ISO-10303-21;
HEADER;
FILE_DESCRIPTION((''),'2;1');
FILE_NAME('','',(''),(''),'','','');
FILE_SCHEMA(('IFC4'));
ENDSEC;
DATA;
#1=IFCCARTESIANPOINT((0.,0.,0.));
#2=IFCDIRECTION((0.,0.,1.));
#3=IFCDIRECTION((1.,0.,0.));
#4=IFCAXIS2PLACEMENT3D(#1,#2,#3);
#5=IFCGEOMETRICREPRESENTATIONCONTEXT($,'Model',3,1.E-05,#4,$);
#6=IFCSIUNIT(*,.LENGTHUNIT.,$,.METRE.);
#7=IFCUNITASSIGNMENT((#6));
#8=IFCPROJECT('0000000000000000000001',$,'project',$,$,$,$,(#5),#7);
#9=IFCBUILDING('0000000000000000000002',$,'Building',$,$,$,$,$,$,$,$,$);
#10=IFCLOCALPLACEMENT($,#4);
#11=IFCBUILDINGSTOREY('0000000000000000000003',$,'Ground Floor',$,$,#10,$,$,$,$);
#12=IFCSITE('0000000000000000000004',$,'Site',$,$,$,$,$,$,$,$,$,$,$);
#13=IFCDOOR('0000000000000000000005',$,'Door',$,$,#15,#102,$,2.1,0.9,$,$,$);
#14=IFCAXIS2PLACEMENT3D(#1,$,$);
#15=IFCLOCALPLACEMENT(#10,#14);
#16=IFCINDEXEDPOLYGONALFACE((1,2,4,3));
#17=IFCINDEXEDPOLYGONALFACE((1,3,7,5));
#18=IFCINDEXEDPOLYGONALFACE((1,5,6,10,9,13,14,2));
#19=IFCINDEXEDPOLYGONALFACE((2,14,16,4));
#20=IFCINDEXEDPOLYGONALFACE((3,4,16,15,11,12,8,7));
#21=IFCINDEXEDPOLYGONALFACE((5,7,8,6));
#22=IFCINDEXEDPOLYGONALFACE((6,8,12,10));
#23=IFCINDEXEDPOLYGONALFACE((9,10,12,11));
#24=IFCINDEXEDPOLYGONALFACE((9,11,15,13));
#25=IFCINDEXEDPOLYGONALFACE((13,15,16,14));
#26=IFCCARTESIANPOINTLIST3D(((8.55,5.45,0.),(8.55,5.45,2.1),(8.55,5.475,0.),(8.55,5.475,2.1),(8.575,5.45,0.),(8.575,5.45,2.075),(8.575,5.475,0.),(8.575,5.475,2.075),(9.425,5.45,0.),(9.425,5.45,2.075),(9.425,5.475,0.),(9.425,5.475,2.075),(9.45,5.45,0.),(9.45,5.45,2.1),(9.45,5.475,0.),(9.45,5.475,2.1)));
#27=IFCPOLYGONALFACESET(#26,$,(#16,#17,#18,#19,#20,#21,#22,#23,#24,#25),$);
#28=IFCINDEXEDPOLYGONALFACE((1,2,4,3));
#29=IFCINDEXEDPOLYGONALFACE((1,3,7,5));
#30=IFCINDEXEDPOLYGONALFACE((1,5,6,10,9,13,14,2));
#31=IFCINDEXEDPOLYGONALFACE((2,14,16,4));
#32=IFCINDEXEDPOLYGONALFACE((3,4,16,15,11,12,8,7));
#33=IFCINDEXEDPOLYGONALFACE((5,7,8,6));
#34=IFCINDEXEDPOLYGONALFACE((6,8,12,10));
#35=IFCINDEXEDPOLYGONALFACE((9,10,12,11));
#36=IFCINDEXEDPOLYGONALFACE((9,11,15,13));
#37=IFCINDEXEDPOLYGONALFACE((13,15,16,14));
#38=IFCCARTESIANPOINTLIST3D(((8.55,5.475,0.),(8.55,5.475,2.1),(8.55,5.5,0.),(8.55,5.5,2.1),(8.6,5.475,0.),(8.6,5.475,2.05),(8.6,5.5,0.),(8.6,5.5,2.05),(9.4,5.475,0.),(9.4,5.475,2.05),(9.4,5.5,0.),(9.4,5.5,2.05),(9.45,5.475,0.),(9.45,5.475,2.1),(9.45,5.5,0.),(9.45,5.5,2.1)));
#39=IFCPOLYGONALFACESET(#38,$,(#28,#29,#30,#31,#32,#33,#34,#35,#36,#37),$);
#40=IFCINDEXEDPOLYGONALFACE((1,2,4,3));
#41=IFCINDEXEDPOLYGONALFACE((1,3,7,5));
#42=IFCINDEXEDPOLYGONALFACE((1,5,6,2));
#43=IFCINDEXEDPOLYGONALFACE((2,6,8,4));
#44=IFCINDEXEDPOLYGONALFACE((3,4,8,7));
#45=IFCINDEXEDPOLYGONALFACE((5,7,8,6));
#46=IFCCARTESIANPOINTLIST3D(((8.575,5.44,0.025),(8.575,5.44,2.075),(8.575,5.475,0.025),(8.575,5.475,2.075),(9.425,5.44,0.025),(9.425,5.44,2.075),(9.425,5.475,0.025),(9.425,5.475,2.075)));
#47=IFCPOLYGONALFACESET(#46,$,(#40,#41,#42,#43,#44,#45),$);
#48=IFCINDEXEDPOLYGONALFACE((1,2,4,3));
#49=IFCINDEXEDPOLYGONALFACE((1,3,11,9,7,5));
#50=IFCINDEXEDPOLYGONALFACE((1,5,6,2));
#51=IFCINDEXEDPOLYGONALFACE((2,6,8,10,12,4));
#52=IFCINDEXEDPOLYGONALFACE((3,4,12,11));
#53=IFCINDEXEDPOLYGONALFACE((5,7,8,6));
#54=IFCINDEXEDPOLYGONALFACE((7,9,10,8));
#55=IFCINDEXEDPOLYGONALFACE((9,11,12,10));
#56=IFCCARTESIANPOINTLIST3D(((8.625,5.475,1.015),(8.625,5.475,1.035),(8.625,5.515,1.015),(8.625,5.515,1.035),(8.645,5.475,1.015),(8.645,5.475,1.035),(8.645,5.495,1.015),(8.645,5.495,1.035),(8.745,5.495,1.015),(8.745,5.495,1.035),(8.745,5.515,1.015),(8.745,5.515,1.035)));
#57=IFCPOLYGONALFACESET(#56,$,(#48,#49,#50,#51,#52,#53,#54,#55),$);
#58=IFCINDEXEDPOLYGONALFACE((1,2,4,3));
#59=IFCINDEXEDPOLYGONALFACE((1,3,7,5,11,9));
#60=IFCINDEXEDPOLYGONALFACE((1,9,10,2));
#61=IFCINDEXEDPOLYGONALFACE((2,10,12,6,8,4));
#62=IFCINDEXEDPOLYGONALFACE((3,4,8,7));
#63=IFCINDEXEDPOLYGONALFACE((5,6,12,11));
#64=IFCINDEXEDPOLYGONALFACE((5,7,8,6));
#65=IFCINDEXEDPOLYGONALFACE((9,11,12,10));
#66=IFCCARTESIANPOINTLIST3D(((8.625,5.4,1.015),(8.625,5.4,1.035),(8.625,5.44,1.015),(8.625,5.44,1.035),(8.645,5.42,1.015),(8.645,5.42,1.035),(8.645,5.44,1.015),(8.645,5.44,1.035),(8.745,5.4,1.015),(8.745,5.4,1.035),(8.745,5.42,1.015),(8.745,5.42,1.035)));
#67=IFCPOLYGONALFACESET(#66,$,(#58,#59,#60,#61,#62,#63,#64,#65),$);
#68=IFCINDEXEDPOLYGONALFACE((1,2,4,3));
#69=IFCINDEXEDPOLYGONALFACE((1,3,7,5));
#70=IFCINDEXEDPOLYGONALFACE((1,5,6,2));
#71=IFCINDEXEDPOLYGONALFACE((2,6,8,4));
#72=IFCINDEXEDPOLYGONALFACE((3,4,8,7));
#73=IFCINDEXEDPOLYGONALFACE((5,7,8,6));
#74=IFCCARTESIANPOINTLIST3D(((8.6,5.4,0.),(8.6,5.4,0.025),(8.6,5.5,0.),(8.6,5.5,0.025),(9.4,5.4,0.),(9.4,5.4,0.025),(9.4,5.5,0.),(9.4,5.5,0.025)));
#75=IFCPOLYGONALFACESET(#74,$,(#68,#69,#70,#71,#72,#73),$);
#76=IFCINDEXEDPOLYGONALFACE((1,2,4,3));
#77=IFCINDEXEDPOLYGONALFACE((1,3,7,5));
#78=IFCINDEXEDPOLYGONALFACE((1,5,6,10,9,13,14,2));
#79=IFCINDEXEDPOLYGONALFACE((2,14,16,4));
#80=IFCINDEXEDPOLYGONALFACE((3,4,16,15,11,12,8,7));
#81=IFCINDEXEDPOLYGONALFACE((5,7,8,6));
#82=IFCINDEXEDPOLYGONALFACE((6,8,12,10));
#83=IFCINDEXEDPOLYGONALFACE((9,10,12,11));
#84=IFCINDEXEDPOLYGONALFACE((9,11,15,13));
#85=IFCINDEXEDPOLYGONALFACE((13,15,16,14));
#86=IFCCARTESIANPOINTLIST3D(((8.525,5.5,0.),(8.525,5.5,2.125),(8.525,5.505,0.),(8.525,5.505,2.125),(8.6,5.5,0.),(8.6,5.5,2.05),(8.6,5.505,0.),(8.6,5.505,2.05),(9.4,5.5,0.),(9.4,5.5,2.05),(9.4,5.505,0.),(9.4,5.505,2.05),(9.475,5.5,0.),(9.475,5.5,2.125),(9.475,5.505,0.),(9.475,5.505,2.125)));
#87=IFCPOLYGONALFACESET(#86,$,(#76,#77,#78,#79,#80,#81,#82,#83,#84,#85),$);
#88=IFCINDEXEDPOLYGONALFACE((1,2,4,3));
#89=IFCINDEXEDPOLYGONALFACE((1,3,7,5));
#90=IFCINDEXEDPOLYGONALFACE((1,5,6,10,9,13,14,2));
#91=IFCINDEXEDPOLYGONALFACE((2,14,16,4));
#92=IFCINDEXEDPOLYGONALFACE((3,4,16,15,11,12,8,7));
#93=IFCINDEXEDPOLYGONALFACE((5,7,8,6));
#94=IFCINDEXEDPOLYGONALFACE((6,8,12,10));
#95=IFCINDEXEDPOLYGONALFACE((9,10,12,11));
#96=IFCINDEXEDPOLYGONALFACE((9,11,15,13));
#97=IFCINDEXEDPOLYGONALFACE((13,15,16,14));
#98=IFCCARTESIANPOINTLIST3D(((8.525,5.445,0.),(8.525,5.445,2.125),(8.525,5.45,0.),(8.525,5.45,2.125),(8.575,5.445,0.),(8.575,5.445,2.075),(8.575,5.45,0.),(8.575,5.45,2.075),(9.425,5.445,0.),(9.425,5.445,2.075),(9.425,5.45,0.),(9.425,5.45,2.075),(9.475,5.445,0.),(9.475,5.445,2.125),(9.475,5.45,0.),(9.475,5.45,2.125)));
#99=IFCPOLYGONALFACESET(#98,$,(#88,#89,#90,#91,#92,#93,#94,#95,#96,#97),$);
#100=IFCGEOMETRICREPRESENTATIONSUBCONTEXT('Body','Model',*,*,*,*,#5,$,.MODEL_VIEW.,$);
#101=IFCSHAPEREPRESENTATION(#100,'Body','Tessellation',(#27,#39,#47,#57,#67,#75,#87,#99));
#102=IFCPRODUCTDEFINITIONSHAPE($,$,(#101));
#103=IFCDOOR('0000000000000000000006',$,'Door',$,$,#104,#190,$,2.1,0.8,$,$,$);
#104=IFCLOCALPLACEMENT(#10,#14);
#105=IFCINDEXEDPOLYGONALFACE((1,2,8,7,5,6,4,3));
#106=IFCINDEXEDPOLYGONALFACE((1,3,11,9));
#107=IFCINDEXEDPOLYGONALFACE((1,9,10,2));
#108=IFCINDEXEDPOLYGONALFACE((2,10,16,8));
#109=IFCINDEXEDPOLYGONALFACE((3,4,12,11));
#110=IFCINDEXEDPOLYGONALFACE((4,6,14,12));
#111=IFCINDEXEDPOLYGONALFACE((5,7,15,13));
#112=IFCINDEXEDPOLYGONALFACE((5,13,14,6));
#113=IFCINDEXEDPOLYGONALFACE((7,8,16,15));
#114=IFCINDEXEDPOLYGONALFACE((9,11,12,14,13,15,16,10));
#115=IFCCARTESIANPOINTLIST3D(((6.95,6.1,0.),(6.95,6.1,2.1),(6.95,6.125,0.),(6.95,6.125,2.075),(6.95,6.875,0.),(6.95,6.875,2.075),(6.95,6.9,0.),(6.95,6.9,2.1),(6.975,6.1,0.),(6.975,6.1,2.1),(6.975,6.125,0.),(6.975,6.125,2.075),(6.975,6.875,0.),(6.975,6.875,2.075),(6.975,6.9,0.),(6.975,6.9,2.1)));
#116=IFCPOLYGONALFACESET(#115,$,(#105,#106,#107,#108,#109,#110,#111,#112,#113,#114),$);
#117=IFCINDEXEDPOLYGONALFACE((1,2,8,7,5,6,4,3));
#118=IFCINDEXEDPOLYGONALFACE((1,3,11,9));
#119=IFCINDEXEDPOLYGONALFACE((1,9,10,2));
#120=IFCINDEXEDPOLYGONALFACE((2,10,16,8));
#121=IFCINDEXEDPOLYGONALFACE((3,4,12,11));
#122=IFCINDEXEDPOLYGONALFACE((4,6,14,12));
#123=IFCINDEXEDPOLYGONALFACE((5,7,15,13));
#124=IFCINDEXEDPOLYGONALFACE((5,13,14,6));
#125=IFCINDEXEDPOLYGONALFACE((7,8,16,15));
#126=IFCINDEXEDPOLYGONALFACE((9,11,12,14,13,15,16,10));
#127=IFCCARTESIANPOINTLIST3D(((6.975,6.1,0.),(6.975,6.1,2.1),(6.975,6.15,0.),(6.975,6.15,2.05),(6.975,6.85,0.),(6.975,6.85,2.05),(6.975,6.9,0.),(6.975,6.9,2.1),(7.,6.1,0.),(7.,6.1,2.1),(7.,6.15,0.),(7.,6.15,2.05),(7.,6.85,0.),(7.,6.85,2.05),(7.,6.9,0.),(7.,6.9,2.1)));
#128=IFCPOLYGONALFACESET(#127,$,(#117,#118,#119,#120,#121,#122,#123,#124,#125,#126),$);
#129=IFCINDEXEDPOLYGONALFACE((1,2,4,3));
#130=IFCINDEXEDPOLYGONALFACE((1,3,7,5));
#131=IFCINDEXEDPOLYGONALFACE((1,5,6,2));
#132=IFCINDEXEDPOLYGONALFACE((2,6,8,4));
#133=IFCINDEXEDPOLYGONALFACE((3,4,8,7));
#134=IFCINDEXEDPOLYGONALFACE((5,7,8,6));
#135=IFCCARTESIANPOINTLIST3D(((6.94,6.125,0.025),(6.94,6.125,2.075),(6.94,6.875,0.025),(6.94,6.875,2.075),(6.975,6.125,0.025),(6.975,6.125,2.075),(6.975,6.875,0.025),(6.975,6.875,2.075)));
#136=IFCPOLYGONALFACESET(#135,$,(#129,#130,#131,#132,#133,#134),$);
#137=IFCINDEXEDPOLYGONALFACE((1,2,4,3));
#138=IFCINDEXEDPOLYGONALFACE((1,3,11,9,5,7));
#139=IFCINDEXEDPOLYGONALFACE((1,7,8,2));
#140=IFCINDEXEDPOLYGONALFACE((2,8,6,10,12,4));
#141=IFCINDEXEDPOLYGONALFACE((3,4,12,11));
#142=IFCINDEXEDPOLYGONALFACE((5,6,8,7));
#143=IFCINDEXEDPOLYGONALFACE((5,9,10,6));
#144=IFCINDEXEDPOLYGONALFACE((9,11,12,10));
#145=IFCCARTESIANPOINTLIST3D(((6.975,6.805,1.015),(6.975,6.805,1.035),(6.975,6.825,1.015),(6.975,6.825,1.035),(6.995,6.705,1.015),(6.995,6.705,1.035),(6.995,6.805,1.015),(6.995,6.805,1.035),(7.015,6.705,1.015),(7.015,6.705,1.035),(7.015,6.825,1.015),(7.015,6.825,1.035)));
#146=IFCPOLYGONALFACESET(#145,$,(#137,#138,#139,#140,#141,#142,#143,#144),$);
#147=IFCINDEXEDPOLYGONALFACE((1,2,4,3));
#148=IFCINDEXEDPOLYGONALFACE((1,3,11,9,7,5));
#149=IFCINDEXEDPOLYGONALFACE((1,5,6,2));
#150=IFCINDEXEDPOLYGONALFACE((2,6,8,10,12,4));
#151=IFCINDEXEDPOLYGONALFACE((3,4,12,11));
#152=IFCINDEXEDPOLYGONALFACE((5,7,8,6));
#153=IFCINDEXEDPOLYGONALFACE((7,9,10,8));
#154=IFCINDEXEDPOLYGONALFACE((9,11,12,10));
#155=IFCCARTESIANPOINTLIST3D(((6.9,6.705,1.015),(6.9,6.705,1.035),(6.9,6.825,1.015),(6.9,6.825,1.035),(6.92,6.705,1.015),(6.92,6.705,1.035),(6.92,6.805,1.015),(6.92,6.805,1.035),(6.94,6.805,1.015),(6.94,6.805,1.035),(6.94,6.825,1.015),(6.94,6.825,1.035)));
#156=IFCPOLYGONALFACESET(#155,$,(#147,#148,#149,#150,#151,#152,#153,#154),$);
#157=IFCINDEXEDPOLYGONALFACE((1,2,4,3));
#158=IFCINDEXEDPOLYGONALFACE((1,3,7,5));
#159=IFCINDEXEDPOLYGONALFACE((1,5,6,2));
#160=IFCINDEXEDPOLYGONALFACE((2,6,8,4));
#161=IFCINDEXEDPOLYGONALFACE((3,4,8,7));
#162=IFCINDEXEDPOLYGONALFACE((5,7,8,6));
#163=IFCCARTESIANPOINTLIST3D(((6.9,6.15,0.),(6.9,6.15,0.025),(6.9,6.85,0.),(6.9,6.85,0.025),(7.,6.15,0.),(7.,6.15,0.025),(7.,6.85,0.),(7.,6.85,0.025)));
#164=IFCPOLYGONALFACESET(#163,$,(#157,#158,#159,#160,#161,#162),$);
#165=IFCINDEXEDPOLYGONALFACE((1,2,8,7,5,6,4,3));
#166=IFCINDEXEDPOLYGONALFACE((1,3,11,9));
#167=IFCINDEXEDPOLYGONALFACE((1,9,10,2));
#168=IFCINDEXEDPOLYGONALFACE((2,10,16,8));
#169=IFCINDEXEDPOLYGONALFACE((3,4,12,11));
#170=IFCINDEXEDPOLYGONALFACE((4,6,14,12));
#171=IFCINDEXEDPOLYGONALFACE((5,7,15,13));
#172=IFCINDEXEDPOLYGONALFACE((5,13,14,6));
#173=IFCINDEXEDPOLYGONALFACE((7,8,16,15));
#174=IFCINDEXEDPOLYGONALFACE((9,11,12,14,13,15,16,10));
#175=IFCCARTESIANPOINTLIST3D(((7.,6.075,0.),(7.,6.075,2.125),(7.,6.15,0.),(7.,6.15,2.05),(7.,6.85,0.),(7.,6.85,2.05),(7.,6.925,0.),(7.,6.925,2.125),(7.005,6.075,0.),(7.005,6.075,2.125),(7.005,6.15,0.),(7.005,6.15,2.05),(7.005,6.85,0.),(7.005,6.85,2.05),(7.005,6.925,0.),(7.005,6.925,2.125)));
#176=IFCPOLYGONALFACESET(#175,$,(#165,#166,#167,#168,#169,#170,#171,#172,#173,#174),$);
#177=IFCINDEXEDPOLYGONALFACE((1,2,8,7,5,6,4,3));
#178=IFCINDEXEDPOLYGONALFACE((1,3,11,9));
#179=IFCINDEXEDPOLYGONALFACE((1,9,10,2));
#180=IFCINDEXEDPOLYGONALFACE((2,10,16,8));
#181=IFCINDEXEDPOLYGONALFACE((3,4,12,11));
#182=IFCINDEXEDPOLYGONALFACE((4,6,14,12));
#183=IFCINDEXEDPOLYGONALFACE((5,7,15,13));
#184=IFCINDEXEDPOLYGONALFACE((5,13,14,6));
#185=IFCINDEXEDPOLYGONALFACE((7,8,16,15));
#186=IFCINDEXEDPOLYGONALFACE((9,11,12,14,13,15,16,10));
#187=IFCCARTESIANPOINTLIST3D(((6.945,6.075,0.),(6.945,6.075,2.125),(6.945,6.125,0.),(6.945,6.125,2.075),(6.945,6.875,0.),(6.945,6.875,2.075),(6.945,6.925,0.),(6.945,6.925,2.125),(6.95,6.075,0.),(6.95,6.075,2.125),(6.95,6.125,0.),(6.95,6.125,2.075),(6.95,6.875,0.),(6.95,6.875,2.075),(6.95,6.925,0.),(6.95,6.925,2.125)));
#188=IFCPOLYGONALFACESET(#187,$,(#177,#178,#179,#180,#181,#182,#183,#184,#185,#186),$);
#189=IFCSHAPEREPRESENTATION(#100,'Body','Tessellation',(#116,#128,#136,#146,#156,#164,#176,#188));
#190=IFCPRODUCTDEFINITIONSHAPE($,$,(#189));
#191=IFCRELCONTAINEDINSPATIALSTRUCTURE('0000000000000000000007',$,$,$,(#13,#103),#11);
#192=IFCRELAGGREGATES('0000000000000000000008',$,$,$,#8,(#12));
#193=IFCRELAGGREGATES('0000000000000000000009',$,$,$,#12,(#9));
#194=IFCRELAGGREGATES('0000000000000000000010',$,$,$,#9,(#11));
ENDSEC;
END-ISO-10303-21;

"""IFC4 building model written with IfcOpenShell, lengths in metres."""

from ifc_helpers import new_model, si_unit, frame, origin_with_axes, place, context, subcontext, project, spatial, line, indexed_curve, outline, extrude, element, save


model = new_model("IFC4")

# Units and contexts
model_context = context("Model", 3, precision=1e-05, world=origin_with_axes())
body_context = subcontext(model_context, "Body", "Model", "MODEL_VIEW")
ifc_project = project(units=[si_unit("LENGTHUNIT", "METRE")], contexts=[model_context])

# Site, building, storey
site = spatial("IfcSite", under=ifc_project, Name="Site")
building = spatial("IfcBuilding", under=site, Name="Building")
storey_placement = place(None, origin_with_axes())
storey = spatial("IfcBuildingStorey", under=building, at=storey_placement, Name="Ground Floor")

# Doors
door_1_placement = place(storey_placement, frame((9.45, 5.5, 0.0), z_axis=(0.0, 0.0, 1.0), x_axis=(-1.0, 0.0, 0.0)))
element("IfcDoor", 1, at=door_1_placement, inside=storey, Name="Door", OverallHeight=2.1, OverallWidth=0.9, context=body_context, shape_type="SweptSolid", body=[
    extrude(outline(indexed_curve([(0.0, 0.0), (0.0, 2.1), (0.9, 2.1), (0.9, 0.0), (0.875, 0.0), (0.875, 2.075), (0.025, 2.075), (0.025, 0.0)], segments=[line(1, 2, 3, 4, 5, 6, 7, 8, 1)])), frame((0.0, 0.025, 0.0), z_axis=(0.0, -1.0, 0.0), x_axis=(1.0, 0.0, 0.0)), (0.0, 0.0, -1.0), 0.025),
    extrude(outline(indexed_curve([(0.0, 0.0), (0.0, 2.1), (0.9, 2.1), (0.9, 0.0), (0.85, 0.0), (0.85, 2.05), (0.05, 2.05), (0.05, 0.0)], segments=[line(1, 2, 3, 4, 5, 6, 7, 8, 1)])), frame((0.0, 0.0, 0.0), z_axis=(0.0, -1.0, 0.0), x_axis=(1.0, 0.0, 0.0)), (0.0, 0.0, -1.0), 0.025),
    extrude(outline(indexed_curve([(0.0, 0.0), (0.85, 0.0), (0.85, 0.035), (0.0, 0.035)], segments=[line(1, 2, 3, 4, 1)])), frame((0.025, 0.025, 0.025), z_axis=(0.0, 0.0, 1.0), x_axis=(1.0, 0.0, 0.0)), (0.0, 0.0, 1.0), 2.05),
    extrude(outline(indexed_curve([(0.0, 0.0), (0.0, -0.04), (-0.12, -0.04), (-0.12, -0.02), (-0.02, -0.02), (-0.02, 0.0)], segments=[line(1, 2, 3, 4, 5, 6, 1)])), frame((0.825, 0.025, 1.015), z_axis=(0.0, 0.0, 1.0), x_axis=(1.0, 0.0, 0.0)), (0.0, 0.0, 1.0), 0.02),
    extrude(outline(indexed_curve([(0.0, 0.0), (0.0, 0.04), (-0.12, 0.04), (-0.12, 0.02), (-0.02, 0.02), (-0.02, 0.0)], segments=[line(1, 2, 3, 4, 5, 6, 1)])), frame((0.825, 0.06, 1.015), z_axis=(0.0, 0.0, 1.0), x_axis=(1.0, 0.0, 0.0)), (0.0, 0.0, 1.0), 0.02),
    extrude(outline(indexed_curve([(0.0, 0.0), (0.8, 0.0), (0.8, 0.1), (0.0, 0.1)], segments=[line(1, 2, 3, 4, 1)])), frame((0.05, 0.0, 0.0), z_axis=(0.0, 0.0, 1.0), x_axis=(1.0, 0.0, 0.0)), (0.0, 0.0, 1.0), 0.025),
    extrude(outline(indexed_curve([(0.0, 0.0), (0.0, 2.125), (0.95, 2.125), (0.95, 0.0), (0.875, 0.0), (0.875, 2.05), (0.075, 2.05), (0.075, 0.0)], segments=[line(1, 2, 3, 4, 5, 6, 7, 8, 1)])), frame((-0.025, -0.005, 0.0), z_axis=(0.0, -1.0, 0.0), x_axis=(1.0, 0.0, 0.0)), (0.0, 0.0, -1.0), 0.005),
    extrude(outline(indexed_curve([(0.0, 0.0), (0.0, 2.125), (0.95, 2.125), (0.95, 0.0), (0.9, 0.0), (0.9, 2.075), (0.05, 2.075), (0.05, 0.0)], segments=[line(1, 2, 3, 4, 5, 6, 7, 8, 1)])), frame((-0.025, 0.05, 0.0), z_axis=(0.0, -1.0, 0.0), x_axis=(1.0, 0.0, 0.0)), (0.0, 0.0, -1.0), 0.005),
])
door_2_placement = place(storey_placement, frame((7.0, 6.1, 0.0), z_axis=(0.0, 0.0, 1.0), x_axis=(0.0, 1.0, 0.0)))
element("IfcDoor", 2, at=door_2_placement, inside=storey, Name="Door", OverallHeight=2.1, OverallWidth=0.8, context=body_context, shape_type="SweptSolid", body=[
    extrude(outline(indexed_curve([(0.0, 0.0), (0.0, 2.1), (0.8, 2.1), (0.8, 0.0), (0.775, 0.0), (0.775, 2.075), (0.025, 2.075), (0.025, 0.0)], segments=[line(1, 2, 3, 4, 5, 6, 7, 8, 1)])), frame((0.0, 0.025, 0.0), z_axis=(0.0, -1.0, 0.0), x_axis=(1.0, 0.0, 0.0)), (0.0, 0.0, -1.0), 0.025),
    extrude(outline(indexed_curve([(0.0, 0.0), (0.0, 2.1), (0.8, 2.1), (0.8, 0.0), (0.75, 0.0), (0.75, 2.05), (0.05, 2.05), (0.05, 0.0)], segments=[line(1, 2, 3, 4, 5, 6, 7, 8, 1)])), frame((0.0, 0.0, 0.0), z_axis=(0.0, -1.0, 0.0), x_axis=(1.0, 0.0, 0.0)), (0.0, 0.0, -1.0), 0.025),
    extrude(outline(indexed_curve([(0.0, 0.0), (0.75, 0.0), (0.75, 0.035), (0.0, 0.035)], segments=[line(1, 2, 3, 4, 1)])), frame((0.025, 0.025, 0.025), z_axis=(0.0, 0.0, 1.0), x_axis=(1.0, 0.0, 0.0)), (0.0, 0.0, 1.0), 2.05),
    extrude(outline(indexed_curve([(0.0, 0.0), (0.0, -0.04), (-0.12, -0.04), (-0.12, -0.02), (-0.02, -0.02), (-0.02, 0.0)], segments=[line(1, 2, 3, 4, 5, 6, 1)])), frame((0.725, 0.025, 1.015), z_axis=(0.0, 0.0, 1.0), x_axis=(1.0, 0.0, 0.0)), (0.0, 0.0, 1.0), 0.02),
    extrude(outline(indexed_curve([(0.0, 0.0), (0.0, 0.04), (-0.12, 0.04), (-0.12, 0.02), (-0.02, 0.02), (-0.02, 0.0)], segments=[line(1, 2, 3, 4, 5, 6, 1)])), frame((0.725, 0.06, 1.015), z_axis=(0.0, 0.0, 1.0), x_axis=(1.0, 0.0, 0.0)), (0.0, 0.0, 1.0), 0.02),
    extrude(outline(indexed_curve([(0.0, 0.0), (0.7, 0.0), (0.7, 0.1), (0.0, 0.1)], segments=[line(1, 2, 3, 4, 1)])), frame((0.05, 0.0, 0.0), z_axis=(0.0, 0.0, 1.0), x_axis=(1.0, 0.0, 0.0)), (0.0, 0.0, 1.0), 0.025),
    extrude(outline(indexed_curve([(0.0, 0.0), (0.0, 2.125), (0.85, 2.125), (0.85, 0.0), (0.775, 0.0), (0.775, 2.05), (0.075, 2.05), (0.075, 0.0)], segments=[line(1, 2, 3, 4, 5, 6, 7, 8, 1)])), frame((-0.025, -0.005, 0.0), z_axis=(0.0, -1.0, 0.0), x_axis=(1.0, 0.0, 0.0)), (0.0, 0.0, -1.0), 0.005),
    extrude(outline(indexed_curve([(0.0, 0.0), (0.0, 2.125), (0.85, 2.125), (0.85, 0.0), (0.8, 0.0), (0.8, 2.075), (0.05, 2.075), (0.05, 0.0)], segments=[line(1, 2, 3, 4, 5, 6, 7, 8, 1)])), frame((-0.025, 0.05, 0.0), z_axis=(0.0, -1.0, 0.0), x_axis=(1.0, 0.0, 0.0)), (0.0, 0.0, -1.0), 0.005),
])

save(model, "model.ifc")
